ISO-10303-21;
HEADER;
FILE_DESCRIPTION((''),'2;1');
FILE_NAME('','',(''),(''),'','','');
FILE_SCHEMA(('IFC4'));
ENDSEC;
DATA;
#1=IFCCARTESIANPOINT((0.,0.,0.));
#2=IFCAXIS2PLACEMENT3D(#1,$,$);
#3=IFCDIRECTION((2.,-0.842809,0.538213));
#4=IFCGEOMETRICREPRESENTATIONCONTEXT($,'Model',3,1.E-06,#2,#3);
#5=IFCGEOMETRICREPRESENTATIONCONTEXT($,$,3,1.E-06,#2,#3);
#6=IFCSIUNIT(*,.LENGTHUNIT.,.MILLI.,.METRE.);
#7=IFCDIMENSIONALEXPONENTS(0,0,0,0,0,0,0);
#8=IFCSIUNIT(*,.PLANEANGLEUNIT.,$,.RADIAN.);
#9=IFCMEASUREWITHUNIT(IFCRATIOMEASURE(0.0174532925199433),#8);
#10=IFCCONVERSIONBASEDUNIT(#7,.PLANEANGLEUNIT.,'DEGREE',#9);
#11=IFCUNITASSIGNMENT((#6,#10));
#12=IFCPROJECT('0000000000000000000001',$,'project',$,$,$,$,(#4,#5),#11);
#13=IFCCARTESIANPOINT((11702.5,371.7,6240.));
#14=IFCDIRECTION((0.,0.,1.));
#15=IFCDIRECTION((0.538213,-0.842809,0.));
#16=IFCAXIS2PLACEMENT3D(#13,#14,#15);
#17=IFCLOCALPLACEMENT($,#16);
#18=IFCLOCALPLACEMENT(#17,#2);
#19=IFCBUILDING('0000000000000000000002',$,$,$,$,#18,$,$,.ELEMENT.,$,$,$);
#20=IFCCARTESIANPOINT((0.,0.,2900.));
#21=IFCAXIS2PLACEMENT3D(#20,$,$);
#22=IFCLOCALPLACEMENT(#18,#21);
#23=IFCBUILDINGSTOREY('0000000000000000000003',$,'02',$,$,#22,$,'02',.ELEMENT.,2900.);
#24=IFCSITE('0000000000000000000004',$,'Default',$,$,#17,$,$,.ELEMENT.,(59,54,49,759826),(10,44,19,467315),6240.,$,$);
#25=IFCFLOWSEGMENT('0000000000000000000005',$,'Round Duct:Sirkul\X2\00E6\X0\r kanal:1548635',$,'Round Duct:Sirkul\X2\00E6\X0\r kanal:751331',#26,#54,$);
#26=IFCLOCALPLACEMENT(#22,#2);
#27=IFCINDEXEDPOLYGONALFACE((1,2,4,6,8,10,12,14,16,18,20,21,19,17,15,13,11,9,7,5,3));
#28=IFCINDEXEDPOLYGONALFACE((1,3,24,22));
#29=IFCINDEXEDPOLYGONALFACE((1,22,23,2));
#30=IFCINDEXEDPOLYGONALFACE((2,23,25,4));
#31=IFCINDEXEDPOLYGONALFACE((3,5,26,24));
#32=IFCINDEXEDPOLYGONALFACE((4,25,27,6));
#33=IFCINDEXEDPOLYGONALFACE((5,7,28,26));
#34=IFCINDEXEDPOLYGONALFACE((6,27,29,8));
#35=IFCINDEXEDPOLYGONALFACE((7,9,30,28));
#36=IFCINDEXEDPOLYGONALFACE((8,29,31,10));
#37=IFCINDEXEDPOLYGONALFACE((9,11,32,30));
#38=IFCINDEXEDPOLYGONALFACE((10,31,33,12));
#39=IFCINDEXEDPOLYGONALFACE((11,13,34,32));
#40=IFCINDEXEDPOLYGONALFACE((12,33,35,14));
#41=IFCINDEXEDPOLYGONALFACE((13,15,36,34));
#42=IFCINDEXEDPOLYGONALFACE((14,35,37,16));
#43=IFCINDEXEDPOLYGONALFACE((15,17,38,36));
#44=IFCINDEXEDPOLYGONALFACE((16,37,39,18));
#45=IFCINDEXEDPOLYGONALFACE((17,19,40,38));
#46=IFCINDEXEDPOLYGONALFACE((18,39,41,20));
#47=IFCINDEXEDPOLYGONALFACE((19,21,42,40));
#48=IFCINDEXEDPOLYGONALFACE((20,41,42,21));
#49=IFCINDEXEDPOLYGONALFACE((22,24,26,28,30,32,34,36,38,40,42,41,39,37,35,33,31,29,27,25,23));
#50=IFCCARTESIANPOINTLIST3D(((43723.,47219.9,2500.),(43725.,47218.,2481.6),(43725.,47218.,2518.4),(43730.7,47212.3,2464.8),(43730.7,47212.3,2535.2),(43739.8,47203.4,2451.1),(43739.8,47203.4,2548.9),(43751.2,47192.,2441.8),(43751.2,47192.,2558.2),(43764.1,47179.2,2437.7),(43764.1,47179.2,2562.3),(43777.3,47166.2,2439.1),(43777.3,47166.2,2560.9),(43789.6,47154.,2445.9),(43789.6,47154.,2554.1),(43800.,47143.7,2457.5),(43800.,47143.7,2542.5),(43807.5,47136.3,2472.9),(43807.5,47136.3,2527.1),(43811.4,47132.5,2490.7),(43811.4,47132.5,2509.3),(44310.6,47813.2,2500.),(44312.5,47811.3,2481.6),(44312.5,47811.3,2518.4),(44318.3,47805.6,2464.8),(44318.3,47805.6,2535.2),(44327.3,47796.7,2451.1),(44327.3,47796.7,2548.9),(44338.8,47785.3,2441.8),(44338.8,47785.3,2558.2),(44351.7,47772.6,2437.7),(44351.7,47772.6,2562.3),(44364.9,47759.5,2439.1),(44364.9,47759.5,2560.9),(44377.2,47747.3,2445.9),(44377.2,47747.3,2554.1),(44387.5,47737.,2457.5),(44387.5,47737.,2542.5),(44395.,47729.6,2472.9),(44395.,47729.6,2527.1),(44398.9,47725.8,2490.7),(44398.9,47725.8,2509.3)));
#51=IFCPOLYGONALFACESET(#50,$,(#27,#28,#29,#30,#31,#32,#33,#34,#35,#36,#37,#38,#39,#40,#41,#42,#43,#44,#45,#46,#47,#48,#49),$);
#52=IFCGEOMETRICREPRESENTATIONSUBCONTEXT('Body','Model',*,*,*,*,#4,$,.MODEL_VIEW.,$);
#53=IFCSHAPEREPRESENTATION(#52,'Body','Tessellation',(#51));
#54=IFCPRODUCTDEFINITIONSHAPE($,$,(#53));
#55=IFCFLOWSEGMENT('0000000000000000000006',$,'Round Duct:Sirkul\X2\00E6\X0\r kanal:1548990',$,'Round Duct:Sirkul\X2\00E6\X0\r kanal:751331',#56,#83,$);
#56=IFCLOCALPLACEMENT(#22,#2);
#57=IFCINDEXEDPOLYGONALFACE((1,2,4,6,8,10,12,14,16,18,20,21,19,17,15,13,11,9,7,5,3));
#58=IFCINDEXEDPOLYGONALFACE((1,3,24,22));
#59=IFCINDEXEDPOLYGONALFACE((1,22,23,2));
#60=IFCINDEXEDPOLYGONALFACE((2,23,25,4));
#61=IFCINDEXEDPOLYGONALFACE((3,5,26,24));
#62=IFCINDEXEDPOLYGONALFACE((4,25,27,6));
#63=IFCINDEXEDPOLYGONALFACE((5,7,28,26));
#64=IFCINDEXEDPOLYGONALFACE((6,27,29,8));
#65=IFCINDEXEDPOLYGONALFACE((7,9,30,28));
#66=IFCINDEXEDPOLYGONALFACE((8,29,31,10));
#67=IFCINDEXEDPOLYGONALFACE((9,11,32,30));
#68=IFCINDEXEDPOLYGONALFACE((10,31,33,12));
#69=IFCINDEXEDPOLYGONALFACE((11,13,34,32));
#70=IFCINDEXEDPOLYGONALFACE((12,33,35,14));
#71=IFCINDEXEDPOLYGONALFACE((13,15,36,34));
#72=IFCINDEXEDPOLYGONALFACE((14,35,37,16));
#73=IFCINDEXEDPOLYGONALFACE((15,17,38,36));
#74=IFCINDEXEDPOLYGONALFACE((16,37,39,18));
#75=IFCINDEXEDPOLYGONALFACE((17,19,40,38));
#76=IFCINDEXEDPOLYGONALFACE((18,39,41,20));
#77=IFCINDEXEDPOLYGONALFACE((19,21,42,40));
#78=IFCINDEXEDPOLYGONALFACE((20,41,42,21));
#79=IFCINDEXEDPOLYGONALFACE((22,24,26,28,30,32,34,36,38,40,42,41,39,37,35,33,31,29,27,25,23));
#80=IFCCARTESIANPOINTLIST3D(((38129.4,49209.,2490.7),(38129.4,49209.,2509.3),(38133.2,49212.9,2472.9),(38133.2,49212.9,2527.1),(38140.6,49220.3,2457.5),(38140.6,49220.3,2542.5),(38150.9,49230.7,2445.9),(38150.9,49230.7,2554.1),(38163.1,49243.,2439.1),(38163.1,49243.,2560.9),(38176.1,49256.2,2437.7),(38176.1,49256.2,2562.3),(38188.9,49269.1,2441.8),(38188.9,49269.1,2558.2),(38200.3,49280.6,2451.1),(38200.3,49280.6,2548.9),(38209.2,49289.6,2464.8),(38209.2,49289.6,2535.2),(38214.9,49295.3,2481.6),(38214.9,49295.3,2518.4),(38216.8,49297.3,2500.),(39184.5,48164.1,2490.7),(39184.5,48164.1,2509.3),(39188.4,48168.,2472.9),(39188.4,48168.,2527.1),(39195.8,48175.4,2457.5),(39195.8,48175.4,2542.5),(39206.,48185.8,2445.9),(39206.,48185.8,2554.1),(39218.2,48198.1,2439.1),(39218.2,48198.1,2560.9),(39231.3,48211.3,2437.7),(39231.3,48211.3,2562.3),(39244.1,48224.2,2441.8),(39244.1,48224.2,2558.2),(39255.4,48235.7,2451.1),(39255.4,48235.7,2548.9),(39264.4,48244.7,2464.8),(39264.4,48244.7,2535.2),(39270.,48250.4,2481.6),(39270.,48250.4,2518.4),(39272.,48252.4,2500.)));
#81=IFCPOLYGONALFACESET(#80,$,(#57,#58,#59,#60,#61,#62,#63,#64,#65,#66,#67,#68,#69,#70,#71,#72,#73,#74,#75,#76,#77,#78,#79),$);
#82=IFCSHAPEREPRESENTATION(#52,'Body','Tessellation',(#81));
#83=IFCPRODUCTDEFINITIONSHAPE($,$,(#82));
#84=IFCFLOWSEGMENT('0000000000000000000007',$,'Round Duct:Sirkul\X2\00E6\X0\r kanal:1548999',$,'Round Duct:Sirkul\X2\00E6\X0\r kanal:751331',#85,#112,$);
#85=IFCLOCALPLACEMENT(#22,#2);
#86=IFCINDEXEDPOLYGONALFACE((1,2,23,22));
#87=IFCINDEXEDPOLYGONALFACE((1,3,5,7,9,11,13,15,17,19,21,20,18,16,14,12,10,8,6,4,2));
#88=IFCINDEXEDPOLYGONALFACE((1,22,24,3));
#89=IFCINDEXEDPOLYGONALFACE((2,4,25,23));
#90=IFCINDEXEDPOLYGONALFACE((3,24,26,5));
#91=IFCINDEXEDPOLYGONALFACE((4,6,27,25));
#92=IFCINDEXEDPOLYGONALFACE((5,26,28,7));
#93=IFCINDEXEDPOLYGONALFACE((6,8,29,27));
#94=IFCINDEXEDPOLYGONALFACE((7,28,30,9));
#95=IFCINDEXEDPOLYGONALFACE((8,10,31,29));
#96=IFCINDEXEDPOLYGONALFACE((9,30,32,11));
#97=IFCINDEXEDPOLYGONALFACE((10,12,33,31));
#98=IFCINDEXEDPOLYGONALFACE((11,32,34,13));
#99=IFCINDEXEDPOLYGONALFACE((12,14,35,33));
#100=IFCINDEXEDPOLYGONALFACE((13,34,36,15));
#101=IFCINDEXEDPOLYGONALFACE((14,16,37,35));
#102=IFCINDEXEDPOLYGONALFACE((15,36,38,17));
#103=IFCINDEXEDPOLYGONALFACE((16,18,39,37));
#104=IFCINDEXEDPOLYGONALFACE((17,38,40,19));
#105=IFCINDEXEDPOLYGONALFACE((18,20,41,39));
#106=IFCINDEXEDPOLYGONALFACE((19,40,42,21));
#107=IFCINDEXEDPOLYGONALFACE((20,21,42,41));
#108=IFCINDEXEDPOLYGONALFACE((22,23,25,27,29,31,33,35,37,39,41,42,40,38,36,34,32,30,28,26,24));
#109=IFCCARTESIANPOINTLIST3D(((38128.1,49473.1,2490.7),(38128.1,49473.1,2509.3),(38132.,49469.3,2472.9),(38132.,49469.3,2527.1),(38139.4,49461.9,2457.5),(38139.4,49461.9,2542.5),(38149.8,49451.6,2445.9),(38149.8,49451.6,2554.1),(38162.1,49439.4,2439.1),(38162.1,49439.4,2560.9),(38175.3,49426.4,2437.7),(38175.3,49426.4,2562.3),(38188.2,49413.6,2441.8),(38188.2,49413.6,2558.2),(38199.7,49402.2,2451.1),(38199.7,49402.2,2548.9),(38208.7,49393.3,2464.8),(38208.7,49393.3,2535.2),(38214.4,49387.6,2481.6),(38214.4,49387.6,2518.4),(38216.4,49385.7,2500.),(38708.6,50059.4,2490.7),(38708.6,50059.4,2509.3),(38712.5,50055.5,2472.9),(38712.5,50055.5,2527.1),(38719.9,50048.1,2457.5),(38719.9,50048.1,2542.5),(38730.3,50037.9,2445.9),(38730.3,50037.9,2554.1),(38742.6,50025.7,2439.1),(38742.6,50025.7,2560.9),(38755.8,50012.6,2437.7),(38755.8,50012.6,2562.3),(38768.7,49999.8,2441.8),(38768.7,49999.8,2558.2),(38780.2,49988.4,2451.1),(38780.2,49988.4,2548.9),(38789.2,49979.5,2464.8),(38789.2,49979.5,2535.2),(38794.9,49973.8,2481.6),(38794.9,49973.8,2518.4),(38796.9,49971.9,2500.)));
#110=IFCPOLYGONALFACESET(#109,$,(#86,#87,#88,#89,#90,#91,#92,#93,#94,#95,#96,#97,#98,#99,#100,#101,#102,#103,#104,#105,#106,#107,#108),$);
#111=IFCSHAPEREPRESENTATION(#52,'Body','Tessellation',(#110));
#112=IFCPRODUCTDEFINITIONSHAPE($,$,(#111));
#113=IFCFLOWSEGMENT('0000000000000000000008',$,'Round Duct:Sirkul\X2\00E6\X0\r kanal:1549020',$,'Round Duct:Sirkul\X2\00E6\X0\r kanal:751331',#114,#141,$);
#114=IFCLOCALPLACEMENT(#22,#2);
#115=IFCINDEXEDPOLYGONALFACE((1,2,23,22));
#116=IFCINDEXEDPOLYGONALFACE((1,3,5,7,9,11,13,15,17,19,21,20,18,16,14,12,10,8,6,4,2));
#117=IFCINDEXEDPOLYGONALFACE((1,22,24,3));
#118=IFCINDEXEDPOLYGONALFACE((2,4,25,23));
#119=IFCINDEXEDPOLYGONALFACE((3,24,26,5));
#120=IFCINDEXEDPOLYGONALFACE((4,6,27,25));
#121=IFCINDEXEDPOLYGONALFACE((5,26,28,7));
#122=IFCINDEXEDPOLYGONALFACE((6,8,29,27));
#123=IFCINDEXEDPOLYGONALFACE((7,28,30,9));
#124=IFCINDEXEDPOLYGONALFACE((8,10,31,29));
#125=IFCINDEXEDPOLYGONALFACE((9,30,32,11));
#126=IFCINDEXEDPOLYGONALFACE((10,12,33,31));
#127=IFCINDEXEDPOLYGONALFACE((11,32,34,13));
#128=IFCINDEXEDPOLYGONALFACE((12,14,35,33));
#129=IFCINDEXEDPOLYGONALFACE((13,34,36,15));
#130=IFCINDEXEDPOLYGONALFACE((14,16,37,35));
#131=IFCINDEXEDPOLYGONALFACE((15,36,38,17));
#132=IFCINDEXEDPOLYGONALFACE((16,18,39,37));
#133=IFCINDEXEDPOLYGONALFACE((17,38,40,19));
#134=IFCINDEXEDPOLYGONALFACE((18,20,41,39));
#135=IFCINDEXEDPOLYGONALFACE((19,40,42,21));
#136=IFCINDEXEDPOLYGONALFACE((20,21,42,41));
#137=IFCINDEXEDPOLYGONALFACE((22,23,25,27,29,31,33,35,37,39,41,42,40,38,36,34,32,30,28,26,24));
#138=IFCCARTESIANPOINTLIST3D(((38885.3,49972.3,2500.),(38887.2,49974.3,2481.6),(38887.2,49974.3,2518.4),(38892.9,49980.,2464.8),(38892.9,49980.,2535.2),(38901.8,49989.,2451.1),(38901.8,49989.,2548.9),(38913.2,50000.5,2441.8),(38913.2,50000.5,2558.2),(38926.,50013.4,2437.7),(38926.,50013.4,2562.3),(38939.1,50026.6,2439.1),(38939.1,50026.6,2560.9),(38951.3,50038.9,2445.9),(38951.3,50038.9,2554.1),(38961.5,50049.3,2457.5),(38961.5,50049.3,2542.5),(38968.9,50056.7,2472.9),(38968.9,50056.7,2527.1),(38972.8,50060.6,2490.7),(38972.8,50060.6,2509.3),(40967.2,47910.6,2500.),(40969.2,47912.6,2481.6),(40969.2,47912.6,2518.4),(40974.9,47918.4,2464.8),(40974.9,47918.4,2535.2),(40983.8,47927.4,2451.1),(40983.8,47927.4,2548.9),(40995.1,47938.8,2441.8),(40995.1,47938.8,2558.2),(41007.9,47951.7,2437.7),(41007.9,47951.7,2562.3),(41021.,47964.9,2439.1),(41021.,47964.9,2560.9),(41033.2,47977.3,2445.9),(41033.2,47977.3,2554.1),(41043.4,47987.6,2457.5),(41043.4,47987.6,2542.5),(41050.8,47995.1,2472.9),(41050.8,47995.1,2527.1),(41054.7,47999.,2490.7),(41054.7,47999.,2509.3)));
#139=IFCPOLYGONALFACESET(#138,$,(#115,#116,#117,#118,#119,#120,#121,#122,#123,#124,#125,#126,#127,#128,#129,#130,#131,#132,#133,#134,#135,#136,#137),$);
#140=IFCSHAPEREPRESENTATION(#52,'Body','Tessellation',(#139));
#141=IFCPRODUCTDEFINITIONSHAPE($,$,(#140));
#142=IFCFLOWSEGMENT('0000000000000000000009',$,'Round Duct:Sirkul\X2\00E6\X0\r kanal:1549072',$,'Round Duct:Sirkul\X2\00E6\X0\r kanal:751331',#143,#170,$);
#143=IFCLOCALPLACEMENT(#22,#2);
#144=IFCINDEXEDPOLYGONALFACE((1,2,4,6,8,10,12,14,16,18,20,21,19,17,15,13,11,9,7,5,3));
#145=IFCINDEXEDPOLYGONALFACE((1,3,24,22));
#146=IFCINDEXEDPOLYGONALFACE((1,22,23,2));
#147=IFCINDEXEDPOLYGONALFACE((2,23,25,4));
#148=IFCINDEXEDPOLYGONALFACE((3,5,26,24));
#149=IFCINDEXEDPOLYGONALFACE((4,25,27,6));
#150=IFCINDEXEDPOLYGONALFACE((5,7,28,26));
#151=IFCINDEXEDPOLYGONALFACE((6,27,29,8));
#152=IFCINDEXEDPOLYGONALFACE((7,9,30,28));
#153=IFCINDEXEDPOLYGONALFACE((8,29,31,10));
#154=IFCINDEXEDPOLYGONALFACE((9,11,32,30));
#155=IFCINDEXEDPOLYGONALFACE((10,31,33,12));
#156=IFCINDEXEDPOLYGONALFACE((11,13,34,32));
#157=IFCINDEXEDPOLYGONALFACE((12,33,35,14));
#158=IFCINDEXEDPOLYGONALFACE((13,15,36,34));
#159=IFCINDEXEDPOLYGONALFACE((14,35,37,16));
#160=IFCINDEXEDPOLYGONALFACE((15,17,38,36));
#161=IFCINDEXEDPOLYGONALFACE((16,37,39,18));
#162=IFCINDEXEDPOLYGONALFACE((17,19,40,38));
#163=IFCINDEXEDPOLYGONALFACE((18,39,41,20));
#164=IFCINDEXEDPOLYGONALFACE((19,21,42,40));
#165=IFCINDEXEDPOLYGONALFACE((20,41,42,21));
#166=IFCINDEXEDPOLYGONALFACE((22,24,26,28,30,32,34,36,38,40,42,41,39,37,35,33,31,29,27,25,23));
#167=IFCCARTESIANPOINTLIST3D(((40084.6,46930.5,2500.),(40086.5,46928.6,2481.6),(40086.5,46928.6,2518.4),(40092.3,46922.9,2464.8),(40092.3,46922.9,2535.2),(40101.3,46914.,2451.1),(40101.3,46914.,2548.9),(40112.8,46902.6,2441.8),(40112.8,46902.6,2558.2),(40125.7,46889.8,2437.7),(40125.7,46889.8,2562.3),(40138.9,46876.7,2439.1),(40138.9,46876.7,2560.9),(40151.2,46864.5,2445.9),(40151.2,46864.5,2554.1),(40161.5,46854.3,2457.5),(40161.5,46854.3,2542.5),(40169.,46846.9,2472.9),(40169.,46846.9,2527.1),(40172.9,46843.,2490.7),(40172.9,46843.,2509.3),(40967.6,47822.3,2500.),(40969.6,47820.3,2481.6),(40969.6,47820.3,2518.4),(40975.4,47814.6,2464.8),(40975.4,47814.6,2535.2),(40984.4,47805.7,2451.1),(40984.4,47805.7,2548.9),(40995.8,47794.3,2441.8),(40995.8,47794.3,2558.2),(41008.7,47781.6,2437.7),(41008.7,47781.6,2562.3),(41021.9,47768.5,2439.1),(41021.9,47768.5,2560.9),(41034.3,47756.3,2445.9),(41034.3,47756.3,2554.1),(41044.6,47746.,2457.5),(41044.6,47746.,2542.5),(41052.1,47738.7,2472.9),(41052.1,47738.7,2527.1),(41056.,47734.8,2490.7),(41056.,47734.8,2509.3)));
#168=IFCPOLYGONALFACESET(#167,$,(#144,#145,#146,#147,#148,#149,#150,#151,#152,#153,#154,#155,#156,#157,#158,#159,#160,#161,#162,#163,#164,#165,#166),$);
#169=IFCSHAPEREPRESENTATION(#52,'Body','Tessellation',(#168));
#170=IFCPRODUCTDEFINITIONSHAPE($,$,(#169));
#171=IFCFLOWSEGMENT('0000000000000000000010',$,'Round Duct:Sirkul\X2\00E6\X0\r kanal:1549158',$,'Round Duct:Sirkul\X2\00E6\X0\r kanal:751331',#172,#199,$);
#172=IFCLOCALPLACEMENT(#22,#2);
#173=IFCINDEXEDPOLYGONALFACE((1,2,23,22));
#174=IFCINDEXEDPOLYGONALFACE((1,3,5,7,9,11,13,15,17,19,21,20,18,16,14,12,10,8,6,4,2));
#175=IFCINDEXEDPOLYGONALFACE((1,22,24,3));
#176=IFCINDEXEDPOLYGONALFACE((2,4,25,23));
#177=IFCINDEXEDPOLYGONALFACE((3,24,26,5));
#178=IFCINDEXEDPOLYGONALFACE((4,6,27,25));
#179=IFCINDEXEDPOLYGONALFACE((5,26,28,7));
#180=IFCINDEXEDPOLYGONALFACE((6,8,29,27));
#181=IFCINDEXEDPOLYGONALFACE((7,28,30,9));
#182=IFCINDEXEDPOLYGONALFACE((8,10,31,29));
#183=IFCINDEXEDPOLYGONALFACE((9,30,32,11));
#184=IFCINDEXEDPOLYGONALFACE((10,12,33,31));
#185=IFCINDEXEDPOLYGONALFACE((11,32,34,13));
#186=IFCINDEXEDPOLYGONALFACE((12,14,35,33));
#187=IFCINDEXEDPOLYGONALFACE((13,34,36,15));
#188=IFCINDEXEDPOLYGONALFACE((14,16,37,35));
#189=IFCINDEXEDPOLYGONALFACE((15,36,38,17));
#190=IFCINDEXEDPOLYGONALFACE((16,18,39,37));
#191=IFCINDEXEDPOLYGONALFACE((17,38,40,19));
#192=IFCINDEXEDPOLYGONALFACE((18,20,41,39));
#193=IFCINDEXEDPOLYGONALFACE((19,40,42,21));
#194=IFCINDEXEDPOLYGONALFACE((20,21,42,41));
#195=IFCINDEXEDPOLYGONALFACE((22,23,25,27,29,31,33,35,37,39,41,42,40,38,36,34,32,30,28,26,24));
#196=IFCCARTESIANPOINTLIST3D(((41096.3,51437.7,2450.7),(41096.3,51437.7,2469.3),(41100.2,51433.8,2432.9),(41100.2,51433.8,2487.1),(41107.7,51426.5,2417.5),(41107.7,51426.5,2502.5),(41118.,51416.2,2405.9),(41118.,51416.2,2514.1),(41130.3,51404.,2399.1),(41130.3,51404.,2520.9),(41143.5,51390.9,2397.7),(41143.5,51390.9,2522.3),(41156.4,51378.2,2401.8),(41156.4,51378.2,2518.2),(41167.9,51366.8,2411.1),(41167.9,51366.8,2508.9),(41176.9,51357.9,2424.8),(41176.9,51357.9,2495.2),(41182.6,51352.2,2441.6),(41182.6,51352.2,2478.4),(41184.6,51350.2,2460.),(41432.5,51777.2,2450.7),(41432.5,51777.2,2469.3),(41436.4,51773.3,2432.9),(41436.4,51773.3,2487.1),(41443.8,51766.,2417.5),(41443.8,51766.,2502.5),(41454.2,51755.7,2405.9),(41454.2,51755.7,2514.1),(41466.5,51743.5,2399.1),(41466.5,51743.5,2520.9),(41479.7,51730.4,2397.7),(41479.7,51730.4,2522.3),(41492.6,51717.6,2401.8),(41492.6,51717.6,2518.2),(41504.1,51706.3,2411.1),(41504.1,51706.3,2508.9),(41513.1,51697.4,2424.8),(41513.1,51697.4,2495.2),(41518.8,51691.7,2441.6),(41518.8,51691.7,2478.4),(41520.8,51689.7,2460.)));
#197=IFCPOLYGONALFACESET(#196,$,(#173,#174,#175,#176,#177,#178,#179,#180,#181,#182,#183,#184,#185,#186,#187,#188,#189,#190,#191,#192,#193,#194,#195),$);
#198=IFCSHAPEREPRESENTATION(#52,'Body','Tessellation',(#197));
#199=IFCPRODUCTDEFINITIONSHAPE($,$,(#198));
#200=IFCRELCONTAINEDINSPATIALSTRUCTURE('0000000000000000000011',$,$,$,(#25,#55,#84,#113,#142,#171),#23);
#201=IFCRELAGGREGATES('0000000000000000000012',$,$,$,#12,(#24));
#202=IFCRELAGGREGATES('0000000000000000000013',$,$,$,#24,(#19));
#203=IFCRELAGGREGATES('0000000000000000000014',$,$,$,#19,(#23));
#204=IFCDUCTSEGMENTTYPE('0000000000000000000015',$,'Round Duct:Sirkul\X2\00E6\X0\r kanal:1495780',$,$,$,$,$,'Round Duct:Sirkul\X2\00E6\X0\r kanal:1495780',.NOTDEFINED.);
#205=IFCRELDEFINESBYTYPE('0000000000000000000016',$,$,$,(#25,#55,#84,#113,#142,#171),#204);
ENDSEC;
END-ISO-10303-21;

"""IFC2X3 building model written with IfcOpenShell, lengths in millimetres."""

from ifc_helpers import new_model, entity, si_unit, converted_unit, direction, frame, origin, origin_2d_with_axis, place, context, subcontext, project, spatial, circle, extrude, type_object, element, save


model = new_model("IFC2X3")

# Units and contexts
model_context = context("Model", 3, precision=1e-06, world=origin(), true_north=direction((2.0, -0.842809, 0.538213)))
context_of_model = context(None, 3, precision=1e-06, world=origin(), true_north=direction((2.0, -0.842809, 0.538213)))
body_context = subcontext(model_context, "Body", "Model", "MODEL_VIEW")
ifc_project = project(units=[si_unit("LENGTHUNIT", "METRE", prefix="MILLI"), converted_unit("PLANEANGLEUNIT", "DEGREE", entity("IfcRatioMeasure", 0.0174532925199433), si_unit("PLANEANGLEUNIT", "RADIAN"), dimensions=[0, 0, 0, 0, 0, 0, 0])], contexts=[model_context, context_of_model])

# Site, building, storey
site_placement = place(None, frame((11702.5, 371.7, 6240.0), z_axis=(0.0, 0.0, 1.0), x_axis=(0.538213, -0.842809, 0.0)))
site = spatial("IfcSite", under=ifc_project, at=site_placement, Name="Default", CompositionType="ELEMENT", RefLatitude=(59, 54, 49, 759826), RefLongitude=(10, 44, 19, 467315), RefElevation=6240.0)
building_placement = place(site_placement, origin())
building = spatial("IfcBuilding", under=site, at=building_placement, CompositionType="ELEMENT")
storey_placement = place(building_placement, frame((0.0, 0.0, 2900.0)))
storey = spatial("IfcBuildingStorey", under=building, at=storey_placement, Name="02", LongName="02", CompositionType="ELEMENT", Elevation=2900.0)

# Flow segments
duct_segment_type_1 = type_object("IfcDuctSegmentType", Name="Round Duct:Sirkulær kanal:1495780", ElementType="Round Duct:Sirkulær kanal:1495780", PredefinedType="NOTDEFINED")
flow_segment_1_placement = place(storey_placement, origin())
element("IfcFlowSegment", 1, at=flow_segment_1_placement, inside=storey, type_object=duct_segment_type_1, Name="Round Duct:Sirkulær kanal:1548635", ObjectType="Round Duct:Sirkulær kanal:751331", context=body_context, shape_type="SweptSolid", body=[
    extrude(circle(Radius=62.5, at=origin_2d_with_axis()), frame((43767.4, 47176.0, 2500.0), z_axis=(0.703643, 0.710554, 0.0), x_axis=(-0.710554, 0.703643, 0.0)), (0.0, 0.0, 1.0), 835.0),
])
flow_segment_2_placement = place(storey_placement, origin())
element("IfcFlowSegment", 2, at=flow_segment_2_placement, inside=storey, type_object=duct_segment_type_1, Name="Round Duct:Sirkulær kanal:1548990", ObjectType="Round Duct:Sirkulær kanal:751331", context=body_context, shape_type="SweptSolid", body=[
    extrude(circle(Radius=62.5, at=origin_2d_with_axis()), frame((38172.8, 49252.9, 2500.0), z_axis=(0.710554, -0.703643, 0.0), x_axis=(0.703643, 0.710554, 0.0)), (0.0, 0.0, 1.0), 1485.0),
])
flow_segment_3_placement = place(storey_placement, origin())
element("IfcFlowSegment", 3, at=flow_segment_3_placement, inside=storey, type_object=duct_segment_type_1, Name="Round Duct:Sirkulær kanal:1548999", ObjectType="Round Duct:Sirkulær kanal:751331", context=body_context, shape_type="SweptSolid", body=[
    extrude(circle(Radius=62.5, at=origin_2d_with_axis()), frame((38172.0, 49429.7, 2500.0), z_axis=(0.703643, 0.710554, 0.0), x_axis=(0.710554, -0.703643, 0.0)), (0.0, 0.0, 1.0), 825.0),
])
flow_segment_4_placement = place(storey_placement, origin())
element("IfcFlowSegment", 4, at=flow_segment_4_placement, inside=storey, type_object=duct_segment_type_1, Name="Round Duct:Sirkulær kanal:1549020", ObjectType="Round Duct:Sirkulær kanal:751331", context=body_context, shape_type="SweptSolid", body=[
    extrude(circle(Radius=62.5, at=origin_2d_with_axis()), frame((38929.3, 50016.7, 2500.0), z_axis=(0.710554, -0.703643, 0.0), x_axis=(-0.703643, -0.710554, 0.0)), (0.0, 0.0, 1.0), 2930.0),
])
flow_segment_5_placement = place(storey_placement, origin())
element("IfcFlowSegment", 5, at=flow_segment_5_placement, inside=storey, type_object=duct_segment_type_1, Name="Round Duct:Sirkulær kanal:1549072", ObjectType="Round Duct:Sirkulær kanal:751331", context=body_context, shape_type="SweptSolid", body=[
    extrude(circle(Radius=62.5, at=origin_2d_with_axis()), frame((40129.0, 46886.5, 2500.0), z_axis=(0.703643, 0.710554, 0.0), x_axis=(-0.710554, 0.703643, 0.0)), (0.0, 0.0, 1.0), 1255.0),
])
flow_segment_6_placement = place(storey_placement, origin())
element("IfcFlowSegment", 6, at=flow_segment_6_placement, inside=storey, type_object=duct_segment_type_1, Name="Round Duct:Sirkulær kanal:1549158", ObjectType="Round Duct:Sirkulær kanal:751331", context=body_context, shape_type="SweptSolid", body=[
    extrude(circle(Radius=62.5, at=origin_2d_with_axis()), frame((41140.2, 51394.2, 2460.0), z_axis=(0.703648, 0.710549, 0.0), x_axis=(0.710549, -0.703648, 0.0)), (0.0, 0.0, 1.0), 477.8),
])

save(model, "model.ifc")
